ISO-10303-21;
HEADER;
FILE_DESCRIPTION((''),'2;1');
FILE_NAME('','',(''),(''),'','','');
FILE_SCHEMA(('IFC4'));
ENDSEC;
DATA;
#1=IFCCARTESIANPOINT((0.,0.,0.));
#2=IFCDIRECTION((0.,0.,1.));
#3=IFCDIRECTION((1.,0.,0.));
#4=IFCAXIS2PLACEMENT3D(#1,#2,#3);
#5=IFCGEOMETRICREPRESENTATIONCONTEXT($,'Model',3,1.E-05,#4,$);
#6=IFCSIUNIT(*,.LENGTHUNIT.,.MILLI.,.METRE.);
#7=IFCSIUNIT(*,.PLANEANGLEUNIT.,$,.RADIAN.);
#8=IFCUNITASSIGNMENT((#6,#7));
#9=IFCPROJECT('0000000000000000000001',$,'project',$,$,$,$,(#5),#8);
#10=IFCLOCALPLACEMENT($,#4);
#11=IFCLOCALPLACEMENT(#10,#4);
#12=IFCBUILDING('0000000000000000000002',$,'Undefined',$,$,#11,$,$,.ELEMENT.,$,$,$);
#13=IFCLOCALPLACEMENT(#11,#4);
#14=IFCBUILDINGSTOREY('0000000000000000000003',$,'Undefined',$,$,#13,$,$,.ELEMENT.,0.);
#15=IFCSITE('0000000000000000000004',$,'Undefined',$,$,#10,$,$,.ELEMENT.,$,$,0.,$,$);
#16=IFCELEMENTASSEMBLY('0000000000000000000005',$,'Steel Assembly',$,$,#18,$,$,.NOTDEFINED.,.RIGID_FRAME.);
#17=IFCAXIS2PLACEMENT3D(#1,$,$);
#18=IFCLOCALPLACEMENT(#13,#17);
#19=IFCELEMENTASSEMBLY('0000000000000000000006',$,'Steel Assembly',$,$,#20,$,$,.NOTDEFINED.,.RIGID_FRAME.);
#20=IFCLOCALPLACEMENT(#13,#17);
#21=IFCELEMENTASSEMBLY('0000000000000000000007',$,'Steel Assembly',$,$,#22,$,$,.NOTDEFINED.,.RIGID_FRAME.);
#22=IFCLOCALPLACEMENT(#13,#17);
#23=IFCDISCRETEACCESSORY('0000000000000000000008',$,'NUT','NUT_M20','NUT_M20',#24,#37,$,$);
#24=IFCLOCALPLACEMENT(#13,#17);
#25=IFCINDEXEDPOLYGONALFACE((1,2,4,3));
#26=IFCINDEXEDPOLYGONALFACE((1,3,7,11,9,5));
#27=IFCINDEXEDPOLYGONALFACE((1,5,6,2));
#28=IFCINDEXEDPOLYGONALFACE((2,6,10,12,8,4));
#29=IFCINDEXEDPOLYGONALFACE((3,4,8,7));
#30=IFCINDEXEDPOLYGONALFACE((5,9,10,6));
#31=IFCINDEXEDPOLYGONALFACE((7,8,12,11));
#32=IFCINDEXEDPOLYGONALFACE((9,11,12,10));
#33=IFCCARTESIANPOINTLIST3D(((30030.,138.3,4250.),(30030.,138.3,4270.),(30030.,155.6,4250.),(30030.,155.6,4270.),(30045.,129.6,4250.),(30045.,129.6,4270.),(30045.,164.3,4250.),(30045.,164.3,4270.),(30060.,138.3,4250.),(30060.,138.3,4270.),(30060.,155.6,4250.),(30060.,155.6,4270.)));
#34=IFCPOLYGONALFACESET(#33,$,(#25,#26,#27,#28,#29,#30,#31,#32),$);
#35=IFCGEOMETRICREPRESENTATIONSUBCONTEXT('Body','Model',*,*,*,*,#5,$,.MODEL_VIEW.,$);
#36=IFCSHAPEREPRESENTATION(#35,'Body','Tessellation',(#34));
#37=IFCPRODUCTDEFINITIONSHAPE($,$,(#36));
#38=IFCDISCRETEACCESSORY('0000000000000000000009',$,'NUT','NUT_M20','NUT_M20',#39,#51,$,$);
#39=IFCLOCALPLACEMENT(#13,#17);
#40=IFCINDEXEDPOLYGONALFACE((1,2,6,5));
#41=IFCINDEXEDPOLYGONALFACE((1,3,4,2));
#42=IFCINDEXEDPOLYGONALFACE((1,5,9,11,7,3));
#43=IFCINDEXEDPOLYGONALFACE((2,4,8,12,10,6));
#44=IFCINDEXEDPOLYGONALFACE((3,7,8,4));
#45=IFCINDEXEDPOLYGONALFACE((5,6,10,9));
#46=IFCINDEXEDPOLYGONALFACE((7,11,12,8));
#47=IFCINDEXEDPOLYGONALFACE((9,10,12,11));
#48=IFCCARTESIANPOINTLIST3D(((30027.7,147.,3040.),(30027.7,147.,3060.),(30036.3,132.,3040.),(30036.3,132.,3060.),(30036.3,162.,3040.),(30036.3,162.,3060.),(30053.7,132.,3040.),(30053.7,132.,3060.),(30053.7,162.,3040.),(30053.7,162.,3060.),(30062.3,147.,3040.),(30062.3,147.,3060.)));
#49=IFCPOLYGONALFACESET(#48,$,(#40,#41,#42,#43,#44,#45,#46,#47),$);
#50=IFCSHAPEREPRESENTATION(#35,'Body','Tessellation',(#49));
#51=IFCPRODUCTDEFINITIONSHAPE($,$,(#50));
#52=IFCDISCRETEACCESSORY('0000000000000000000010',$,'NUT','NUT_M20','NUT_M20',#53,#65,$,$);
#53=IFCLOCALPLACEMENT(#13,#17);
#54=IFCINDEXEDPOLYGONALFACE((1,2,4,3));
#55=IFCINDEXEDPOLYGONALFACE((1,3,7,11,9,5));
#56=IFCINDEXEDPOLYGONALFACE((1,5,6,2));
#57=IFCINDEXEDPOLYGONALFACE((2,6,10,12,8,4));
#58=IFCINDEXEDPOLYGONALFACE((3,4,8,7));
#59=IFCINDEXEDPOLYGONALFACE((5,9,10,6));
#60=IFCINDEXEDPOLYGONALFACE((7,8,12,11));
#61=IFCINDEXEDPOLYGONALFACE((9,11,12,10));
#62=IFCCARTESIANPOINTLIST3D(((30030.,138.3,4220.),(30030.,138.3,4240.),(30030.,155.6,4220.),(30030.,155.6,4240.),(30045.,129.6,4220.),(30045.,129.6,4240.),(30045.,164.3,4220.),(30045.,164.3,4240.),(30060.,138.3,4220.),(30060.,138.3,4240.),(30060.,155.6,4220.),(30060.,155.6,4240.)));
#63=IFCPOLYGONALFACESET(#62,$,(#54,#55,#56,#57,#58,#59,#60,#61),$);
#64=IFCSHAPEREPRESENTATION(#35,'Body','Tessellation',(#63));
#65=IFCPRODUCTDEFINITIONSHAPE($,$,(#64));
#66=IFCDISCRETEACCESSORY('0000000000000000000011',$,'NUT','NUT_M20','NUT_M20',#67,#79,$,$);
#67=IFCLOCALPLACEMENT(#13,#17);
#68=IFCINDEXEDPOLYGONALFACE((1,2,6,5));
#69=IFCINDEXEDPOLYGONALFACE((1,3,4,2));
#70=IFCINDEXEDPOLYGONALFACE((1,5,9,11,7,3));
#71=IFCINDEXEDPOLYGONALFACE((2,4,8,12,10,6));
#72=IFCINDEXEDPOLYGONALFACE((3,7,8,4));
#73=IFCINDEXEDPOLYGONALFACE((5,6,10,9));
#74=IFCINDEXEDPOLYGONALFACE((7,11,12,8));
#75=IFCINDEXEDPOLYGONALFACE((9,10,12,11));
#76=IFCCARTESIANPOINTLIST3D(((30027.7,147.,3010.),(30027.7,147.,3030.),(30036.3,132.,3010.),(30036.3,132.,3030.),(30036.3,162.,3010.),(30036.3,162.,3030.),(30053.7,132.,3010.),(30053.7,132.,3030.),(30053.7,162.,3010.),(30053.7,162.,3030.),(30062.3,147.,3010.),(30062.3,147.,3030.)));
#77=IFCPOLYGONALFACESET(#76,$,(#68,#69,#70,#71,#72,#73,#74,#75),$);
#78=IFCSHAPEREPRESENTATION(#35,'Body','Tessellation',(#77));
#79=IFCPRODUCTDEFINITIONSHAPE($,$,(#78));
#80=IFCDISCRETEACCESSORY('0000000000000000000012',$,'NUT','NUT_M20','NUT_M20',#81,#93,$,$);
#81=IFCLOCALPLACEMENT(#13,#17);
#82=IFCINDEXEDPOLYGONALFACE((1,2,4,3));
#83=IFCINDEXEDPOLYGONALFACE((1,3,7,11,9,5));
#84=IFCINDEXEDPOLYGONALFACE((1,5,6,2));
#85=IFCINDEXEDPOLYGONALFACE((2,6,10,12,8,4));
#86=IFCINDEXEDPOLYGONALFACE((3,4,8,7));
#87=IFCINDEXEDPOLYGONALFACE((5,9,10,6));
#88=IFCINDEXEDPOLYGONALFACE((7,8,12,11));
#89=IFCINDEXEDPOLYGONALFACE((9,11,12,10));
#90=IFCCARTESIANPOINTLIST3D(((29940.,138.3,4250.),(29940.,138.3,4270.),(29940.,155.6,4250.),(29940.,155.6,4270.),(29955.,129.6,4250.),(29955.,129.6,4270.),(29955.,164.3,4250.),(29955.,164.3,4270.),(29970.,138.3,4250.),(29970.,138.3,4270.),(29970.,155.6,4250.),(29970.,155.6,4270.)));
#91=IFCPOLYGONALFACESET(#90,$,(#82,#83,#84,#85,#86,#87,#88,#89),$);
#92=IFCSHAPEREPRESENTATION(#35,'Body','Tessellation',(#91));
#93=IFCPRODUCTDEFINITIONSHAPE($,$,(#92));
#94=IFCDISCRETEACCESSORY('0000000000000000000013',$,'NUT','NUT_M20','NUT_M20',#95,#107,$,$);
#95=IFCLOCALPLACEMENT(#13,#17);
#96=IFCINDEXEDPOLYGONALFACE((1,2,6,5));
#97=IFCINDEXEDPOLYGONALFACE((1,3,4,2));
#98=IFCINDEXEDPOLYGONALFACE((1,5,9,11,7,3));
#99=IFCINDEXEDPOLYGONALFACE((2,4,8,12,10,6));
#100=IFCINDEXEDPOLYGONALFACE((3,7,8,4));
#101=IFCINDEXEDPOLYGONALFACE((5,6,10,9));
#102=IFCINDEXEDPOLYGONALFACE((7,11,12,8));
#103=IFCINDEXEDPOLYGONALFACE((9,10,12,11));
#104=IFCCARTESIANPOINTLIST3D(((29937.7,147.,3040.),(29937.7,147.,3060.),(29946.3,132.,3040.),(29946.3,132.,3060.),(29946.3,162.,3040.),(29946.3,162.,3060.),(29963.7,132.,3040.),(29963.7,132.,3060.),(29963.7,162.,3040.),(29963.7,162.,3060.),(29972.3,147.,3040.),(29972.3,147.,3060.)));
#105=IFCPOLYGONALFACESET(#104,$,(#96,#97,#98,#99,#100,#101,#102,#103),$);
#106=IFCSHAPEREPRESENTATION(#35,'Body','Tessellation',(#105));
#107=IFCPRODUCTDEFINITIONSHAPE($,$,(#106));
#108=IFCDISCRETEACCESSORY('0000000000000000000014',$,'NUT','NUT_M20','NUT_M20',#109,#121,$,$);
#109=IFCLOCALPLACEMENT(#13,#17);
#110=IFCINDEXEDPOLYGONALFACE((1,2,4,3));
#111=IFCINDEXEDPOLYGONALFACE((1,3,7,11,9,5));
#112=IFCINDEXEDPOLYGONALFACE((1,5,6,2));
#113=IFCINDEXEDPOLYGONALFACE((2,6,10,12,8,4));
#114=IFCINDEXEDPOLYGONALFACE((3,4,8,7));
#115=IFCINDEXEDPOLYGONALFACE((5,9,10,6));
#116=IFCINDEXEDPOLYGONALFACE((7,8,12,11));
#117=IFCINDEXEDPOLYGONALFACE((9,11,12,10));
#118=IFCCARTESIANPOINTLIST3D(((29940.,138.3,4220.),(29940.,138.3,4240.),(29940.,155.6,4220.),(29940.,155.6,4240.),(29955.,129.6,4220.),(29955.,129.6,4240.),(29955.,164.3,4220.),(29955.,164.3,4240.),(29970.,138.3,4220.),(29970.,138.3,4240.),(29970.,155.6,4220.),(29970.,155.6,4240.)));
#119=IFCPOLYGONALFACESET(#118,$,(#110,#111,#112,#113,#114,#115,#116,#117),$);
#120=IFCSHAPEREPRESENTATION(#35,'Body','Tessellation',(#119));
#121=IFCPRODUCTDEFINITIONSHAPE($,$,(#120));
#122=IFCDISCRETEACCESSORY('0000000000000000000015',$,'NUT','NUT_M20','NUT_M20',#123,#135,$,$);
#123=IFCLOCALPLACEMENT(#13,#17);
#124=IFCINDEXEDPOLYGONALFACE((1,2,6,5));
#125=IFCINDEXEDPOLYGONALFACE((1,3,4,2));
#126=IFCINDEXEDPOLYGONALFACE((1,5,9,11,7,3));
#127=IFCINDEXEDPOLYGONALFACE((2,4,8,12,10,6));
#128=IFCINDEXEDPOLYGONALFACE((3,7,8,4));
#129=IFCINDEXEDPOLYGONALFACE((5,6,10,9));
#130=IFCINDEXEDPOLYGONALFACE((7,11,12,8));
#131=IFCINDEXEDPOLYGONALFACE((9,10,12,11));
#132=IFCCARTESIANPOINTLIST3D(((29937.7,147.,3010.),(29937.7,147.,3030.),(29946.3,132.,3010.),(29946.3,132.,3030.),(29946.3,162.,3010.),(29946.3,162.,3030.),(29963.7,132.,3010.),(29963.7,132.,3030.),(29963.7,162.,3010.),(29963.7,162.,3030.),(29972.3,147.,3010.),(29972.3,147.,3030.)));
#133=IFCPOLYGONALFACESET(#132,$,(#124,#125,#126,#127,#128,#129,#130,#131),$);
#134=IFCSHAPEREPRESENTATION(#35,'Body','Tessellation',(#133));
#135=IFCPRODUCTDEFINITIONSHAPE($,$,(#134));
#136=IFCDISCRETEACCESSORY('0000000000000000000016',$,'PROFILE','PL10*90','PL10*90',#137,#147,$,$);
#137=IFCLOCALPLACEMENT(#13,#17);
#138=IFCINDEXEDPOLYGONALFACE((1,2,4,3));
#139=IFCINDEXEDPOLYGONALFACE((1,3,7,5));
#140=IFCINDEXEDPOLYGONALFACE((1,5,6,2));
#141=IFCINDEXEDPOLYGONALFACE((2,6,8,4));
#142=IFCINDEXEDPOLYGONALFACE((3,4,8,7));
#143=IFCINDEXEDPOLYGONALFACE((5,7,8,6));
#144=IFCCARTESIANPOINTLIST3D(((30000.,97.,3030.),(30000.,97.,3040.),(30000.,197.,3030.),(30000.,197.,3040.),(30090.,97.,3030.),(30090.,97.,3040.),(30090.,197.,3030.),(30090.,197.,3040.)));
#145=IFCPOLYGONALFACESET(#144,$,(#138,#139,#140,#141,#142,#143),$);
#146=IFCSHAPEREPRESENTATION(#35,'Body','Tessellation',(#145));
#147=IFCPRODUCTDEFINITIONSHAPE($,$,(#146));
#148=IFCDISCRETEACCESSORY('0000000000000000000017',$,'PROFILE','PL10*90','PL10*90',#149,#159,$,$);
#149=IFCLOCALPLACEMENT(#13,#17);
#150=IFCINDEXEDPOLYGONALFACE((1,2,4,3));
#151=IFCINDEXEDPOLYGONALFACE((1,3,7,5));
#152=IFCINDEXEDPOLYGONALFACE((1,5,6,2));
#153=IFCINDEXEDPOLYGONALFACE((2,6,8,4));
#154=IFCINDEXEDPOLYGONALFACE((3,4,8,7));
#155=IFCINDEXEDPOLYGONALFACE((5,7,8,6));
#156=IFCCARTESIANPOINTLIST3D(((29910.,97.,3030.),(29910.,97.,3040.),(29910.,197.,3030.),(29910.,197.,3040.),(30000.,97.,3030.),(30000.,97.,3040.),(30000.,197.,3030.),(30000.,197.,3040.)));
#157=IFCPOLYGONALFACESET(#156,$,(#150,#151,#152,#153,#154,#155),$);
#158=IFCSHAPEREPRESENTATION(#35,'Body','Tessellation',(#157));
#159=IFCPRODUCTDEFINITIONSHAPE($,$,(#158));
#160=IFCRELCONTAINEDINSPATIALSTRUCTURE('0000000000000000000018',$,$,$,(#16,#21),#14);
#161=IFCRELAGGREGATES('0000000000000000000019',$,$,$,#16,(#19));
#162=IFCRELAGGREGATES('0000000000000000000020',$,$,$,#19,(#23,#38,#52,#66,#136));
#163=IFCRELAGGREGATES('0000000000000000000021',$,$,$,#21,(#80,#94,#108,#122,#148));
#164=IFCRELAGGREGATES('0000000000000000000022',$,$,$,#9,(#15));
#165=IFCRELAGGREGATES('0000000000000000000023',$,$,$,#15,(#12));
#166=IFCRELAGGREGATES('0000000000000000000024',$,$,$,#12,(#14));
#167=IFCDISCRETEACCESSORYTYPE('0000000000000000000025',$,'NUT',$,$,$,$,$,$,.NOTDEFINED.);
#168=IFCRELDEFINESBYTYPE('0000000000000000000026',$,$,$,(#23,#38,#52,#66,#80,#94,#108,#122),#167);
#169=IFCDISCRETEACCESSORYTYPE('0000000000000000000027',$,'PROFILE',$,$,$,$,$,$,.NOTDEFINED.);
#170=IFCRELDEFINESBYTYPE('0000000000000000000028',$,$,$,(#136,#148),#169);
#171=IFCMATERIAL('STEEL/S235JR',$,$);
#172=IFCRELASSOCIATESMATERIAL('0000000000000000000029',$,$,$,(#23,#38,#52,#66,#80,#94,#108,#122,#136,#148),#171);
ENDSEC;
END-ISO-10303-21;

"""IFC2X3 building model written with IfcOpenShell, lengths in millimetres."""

from ifc_helpers import new_model, si_unit, frame, origin_with_axes, place, context, subcontext, project, spatial, polyline, outline, extrude, material, type_object, element, aggregate, save


model = new_model("IFC2X3")

# Units and contexts
model_context = context("Model", 3, precision=1e-05, world=origin_with_axes())
body_context = subcontext(model_context, "Body", "Model", "MODEL_VIEW")
ifc_project = project(units=[si_unit("LENGTHUNIT", "METRE", prefix="MILLI"), si_unit("PLANEANGLEUNIT", "RADIAN")], contexts=[model_context])

# Site, building, storey
site_placement = place(None, origin_with_axes())
site = spatial("IfcSite", under=ifc_project, at=site_placement, Name="Undefined", CompositionType="ELEMENT", RefElevation=0.0)
building_placement = place(site_placement, origin_with_axes())
building = spatial("IfcBuilding", under=site, at=building_placement, Name="Undefined", CompositionType="ELEMENT")
storey_placement = place(building_placement, origin_with_axes())
storey = spatial("IfcBuildingStorey", under=building, at=storey_placement, Name="Undefined", CompositionType="ELEMENT", Elevation=0.0)

# Element assemblies
assembly_1_placement = place(storey_placement, origin_with_axes())
assembly_1 = element("IfcElementAssembly", 1, at=assembly_1_placement, inside=storey, Name="Steel Assembly", AssemblyPlace="NOTDEFINED", PredefinedType="RIGID_FRAME")
assembly_2_placement = place(assembly_1_placement, origin_with_axes())
assembly_2 = element("IfcElementAssembly", 2, at=assembly_2_placement, Name="Steel Assembly", AssemblyPlace="NOTDEFINED", PredefinedType="RIGID_FRAME")

# Element assembly
assembly_3_placement = place(storey_placement, origin_with_axes())
assembly_3 = element("IfcElementAssembly", 3, at=assembly_3_placement, inside=storey, Name="Steel Assembly", AssemblyPlace="NOTDEFINED", PredefinedType="RIGID_FRAME")

# Shared definitions
ifc_material_1 = material(Name="STEEL/S235JR")

aggregate(assembly_1, [assembly_2])

# Discrete accessories
discrete_accessory_type_1 = type_object("IfcDiscreteAccessoryType", Name="NUT")
discrete_accessory_1_placement = place(assembly_2_placement, frame((30045.0, 147.0, 4270.0), z_axis=(-1.0, 0.0, 0.0), x_axis=(0.0, 0.0, -1.0)))
discrete_accessory_1 = element("IfcDiscreteAccessory", 4, at=discrete_accessory_1_placement, type_object=discrete_accessory_type_1, material=ifc_material_1, Name="NUT", Description="NUT_M20", ObjectType="NUT_M20", context=body_context, shape_type="SweptSolid", body=[
    extrude(outline(polyline([(8.7, 15.0), (17.3, 0.0), (8.7, -15.0), (-8.7, -15.0), (-17.3, 0.0), (-8.7, 15.0), (8.7, 15.0)])), frame((20.0, 0.0, 0.0), z_axis=(-1.0, 0.0, 0.0), x_axis=(0.0, -1.0, 0.0)), (0.0, 0.0, 1.0), 20.0),
])
discrete_accessory_2_placement = place(assembly_2_placement, frame((30045.0, 147.0, 3060.0), z_axis=(0.0, 1.0, 0.0), x_axis=(0.0, 0.0, -1.0)))
discrete_accessory_2 = element("IfcDiscreteAccessory", 5, at=discrete_accessory_2_placement, type_object=discrete_accessory_type_1, material=ifc_material_1, Name="NUT", Description="NUT_M20", ObjectType="NUT_M20", context=body_context, shape_type="SweptSolid", body=[
    extrude(outline(polyline([(8.7, 15.0), (17.3, 0.0), (8.7, -15.0), (-8.7, -15.0), (-17.3, 0.0), (-8.7, 15.0), (8.7, 15.0)])), frame((20.0, 0.0, 0.0), z_axis=(-1.0, 0.0, 0.0), x_axis=(0.0, -1.0, 0.0)), (0.0, 0.0, 1.0), 20.0),
])
discrete_accessory_3_placement = place(assembly_2_placement, frame((30045.0, 147.0, 4240.0), z_axis=(-1.0, 0.0, 0.0), x_axis=(0.0, 0.0, -1.0)))
discrete_accessory_3 = element("IfcDiscreteAccessory", 6, at=discrete_accessory_3_placement, type_object=discrete_accessory_type_1, material=ifc_material_1, Name="NUT", Description="NUT_M20", ObjectType="NUT_M20", context=body_context, shape_type="SweptSolid", body=[
    extrude(outline(polyline([(8.7, 15.0), (17.3, 0.0), (8.7, -15.0), (-8.7, -15.0), (-17.3, 0.0), (-8.7, 15.0), (8.7, 15.0)])), frame((20.0, 0.0, 0.0), z_axis=(-1.0, 0.0, 0.0), x_axis=(0.0, -1.0, 0.0)), (0.0, 0.0, 1.0), 20.0),
])
discrete_accessory_4_placement = place(assembly_2_placement, frame((30045.0, 147.0, 3030.0), z_axis=(0.0, 1.0, 0.0), x_axis=(0.0, 0.0, -1.0)))
discrete_accessory_4 = element("IfcDiscreteAccessory", 7, at=discrete_accessory_4_placement, type_object=discrete_accessory_type_1, material=ifc_material_1, Name="NUT", Description="NUT_M20", ObjectType="NUT_M20", context=body_context, shape_type="SweptSolid", body=[
    extrude(outline(polyline([(8.7, 15.0), (17.3, 0.0), (8.7, -15.0), (-8.7, -15.0), (-17.3, 0.0), (-8.7, 15.0), (8.7, 15.0)])), frame((20.0, 0.0, 0.0), z_axis=(-1.0, 0.0, 0.0), x_axis=(0.0, -1.0, 0.0)), (0.0, 0.0, 1.0), 20.0),
])
discrete_accessory_5_placement = place(assembly_3_placement, frame((29955.0, 147.0, 4270.0), z_axis=(-1.0, 0.0, 0.0), x_axis=(0.0, 0.0, -1.0)))
discrete_accessory_5 = element("IfcDiscreteAccessory", 8, at=discrete_accessory_5_placement, type_object=discrete_accessory_type_1, material=ifc_material_1, Name="NUT", Description="NUT_M20", ObjectType="NUT_M20", context=body_context, shape_type="SweptSolid", body=[
    extrude(outline(polyline([(8.7, 15.0), (17.3, 0.0), (8.7, -15.0), (-8.7, -15.0), (-17.3, 0.0), (-8.7, 15.0), (8.7, 15.0)])), frame((20.0, 0.0, 0.0), z_axis=(-1.0, 0.0, 0.0), x_axis=(0.0, -1.0, 0.0)), (0.0, 0.0, 1.0), 20.0),
])
discrete_accessory_6_placement = place(assembly_3_placement, frame((29955.0, 147.0, 3060.0), z_axis=(0.0, 1.0, 0.0), x_axis=(0.0, 0.0, -1.0)))
discrete_accessory_6 = element("IfcDiscreteAccessory", 9, at=discrete_accessory_6_placement, type_object=discrete_accessory_type_1, material=ifc_material_1, Name="NUT", Description="NUT_M20", ObjectType="NUT_M20", context=body_context, shape_type="SweptSolid", body=[
    extrude(outline(polyline([(8.7, 15.0), (17.3, 0.0), (8.7, -15.0), (-8.7, -15.0), (-17.3, 0.0), (-8.7, 15.0), (8.7, 15.0)])), frame((20.0, 0.0, 0.0), z_axis=(-1.0, 0.0, 0.0), x_axis=(0.0, -1.0, 0.0)), (0.0, 0.0, 1.0), 20.0),
])
discrete_accessory_7_placement = place(assembly_3_placement, frame((29955.0, 147.0, 4240.0), z_axis=(-1.0, 0.0, 0.0), x_axis=(0.0, 0.0, -1.0)))
discrete_accessory_7 = element("IfcDiscreteAccessory", 10, at=discrete_accessory_7_placement, type_object=discrete_accessory_type_1, material=ifc_material_1, Name="NUT", Description="NUT_M20", ObjectType="NUT_M20", context=body_context, shape_type="SweptSolid", body=[
    extrude(outline(polyline([(8.7, 15.0), (17.3, 0.0), (8.7, -15.0), (-8.7, -15.0), (-17.3, 0.0), (-8.7, 15.0), (8.7, 15.0)])), frame((20.0, 0.0, 0.0), z_axis=(-1.0, 0.0, 0.0), x_axis=(0.0, -1.0, 0.0)), (0.0, 0.0, 1.0), 20.0),
])
discrete_accessory_8_placement = place(assembly_3_placement, frame((29955.0, 147.0, 3030.0), z_axis=(0.0, 1.0, 0.0), x_axis=(0.0, 0.0, -1.0)))
discrete_accessory_8 = element("IfcDiscreteAccessory", 11, at=discrete_accessory_8_placement, type_object=discrete_accessory_type_1, material=ifc_material_1, Name="NUT", Description="NUT_M20", ObjectType="NUT_M20", context=body_context, shape_type="SweptSolid", body=[
    extrude(outline(polyline([(8.7, 15.0), (17.3, 0.0), (8.7, -15.0), (-8.7, -15.0), (-17.3, 0.0), (-8.7, 15.0), (8.7, 15.0)])), frame((20.0, 0.0, 0.0), z_axis=(-1.0, 0.0, 0.0), x_axis=(0.0, -1.0, 0.0)), (0.0, 0.0, 1.0), 20.0),
])
discrete_accessory_type_2 = type_object("IfcDiscreteAccessoryType", Name="PROFILE")
discrete_accessory_9_placement = place(assembly_2_placement, frame((30045.0, 97.0, 3035.0), z_axis=(0.0, 0.0, -1.0), x_axis=(0.0, 1.0, 0.0)))
discrete_accessory_9 = element("IfcDiscreteAccessory", 12, at=discrete_accessory_9_placement, type_object=discrete_accessory_type_2, material=ifc_material_1, Name="PROFILE", Description="PL10*90", ObjectType="PL10*90", context=body_context, shape_type="SweptSolid", body=[
    extrude(outline(polyline([(0.0, -45.0), (0.0, 45.0), (100.0, 45.0), (100.0, -45.0), (0.0, -45.0)])), frame((0.0, 0.0, -5.0), z_axis=(0.0, 0.0, 1.0), x_axis=(1.0, 0.0, 0.0)), (0.0, 0.0, 1.0), 10.0),
])
aggregate(assembly_2, [discrete_accessory_1, discrete_accessory_2, discrete_accessory_3, discrete_accessory_4, discrete_accessory_9])
discrete_accessory_10_placement = place(assembly_3_placement, frame((29955.0, 97.0, 3035.0), z_axis=(0.0, 0.0, -1.0), x_axis=(0.0, 1.0, 0.0)))
discrete_accessory_10 = element("IfcDiscreteAccessory", 13, at=discrete_accessory_10_placement, type_object=discrete_accessory_type_2, material=ifc_material_1, Name="PROFILE", Description="PL10*90", ObjectType="PL10*90", context=body_context, shape_type="SweptSolid", body=[
    extrude(outline(polyline([(0.0, -45.0), (0.0, 45.0), (100.0, 45.0), (100.0, -45.0), (0.0, -45.0)])), frame((0.0, 0.0, -5.0), z_axis=(0.0, 0.0, 1.0), x_axis=(1.0, 0.0, 0.0)), (0.0, 0.0, 1.0), 10.0),
])
aggregate(assembly_3, [discrete_accessory_5, discrete_accessory_6, discrete_accessory_7, discrete_accessory_8, discrete_accessory_10])

save(model, "model.ifc")
